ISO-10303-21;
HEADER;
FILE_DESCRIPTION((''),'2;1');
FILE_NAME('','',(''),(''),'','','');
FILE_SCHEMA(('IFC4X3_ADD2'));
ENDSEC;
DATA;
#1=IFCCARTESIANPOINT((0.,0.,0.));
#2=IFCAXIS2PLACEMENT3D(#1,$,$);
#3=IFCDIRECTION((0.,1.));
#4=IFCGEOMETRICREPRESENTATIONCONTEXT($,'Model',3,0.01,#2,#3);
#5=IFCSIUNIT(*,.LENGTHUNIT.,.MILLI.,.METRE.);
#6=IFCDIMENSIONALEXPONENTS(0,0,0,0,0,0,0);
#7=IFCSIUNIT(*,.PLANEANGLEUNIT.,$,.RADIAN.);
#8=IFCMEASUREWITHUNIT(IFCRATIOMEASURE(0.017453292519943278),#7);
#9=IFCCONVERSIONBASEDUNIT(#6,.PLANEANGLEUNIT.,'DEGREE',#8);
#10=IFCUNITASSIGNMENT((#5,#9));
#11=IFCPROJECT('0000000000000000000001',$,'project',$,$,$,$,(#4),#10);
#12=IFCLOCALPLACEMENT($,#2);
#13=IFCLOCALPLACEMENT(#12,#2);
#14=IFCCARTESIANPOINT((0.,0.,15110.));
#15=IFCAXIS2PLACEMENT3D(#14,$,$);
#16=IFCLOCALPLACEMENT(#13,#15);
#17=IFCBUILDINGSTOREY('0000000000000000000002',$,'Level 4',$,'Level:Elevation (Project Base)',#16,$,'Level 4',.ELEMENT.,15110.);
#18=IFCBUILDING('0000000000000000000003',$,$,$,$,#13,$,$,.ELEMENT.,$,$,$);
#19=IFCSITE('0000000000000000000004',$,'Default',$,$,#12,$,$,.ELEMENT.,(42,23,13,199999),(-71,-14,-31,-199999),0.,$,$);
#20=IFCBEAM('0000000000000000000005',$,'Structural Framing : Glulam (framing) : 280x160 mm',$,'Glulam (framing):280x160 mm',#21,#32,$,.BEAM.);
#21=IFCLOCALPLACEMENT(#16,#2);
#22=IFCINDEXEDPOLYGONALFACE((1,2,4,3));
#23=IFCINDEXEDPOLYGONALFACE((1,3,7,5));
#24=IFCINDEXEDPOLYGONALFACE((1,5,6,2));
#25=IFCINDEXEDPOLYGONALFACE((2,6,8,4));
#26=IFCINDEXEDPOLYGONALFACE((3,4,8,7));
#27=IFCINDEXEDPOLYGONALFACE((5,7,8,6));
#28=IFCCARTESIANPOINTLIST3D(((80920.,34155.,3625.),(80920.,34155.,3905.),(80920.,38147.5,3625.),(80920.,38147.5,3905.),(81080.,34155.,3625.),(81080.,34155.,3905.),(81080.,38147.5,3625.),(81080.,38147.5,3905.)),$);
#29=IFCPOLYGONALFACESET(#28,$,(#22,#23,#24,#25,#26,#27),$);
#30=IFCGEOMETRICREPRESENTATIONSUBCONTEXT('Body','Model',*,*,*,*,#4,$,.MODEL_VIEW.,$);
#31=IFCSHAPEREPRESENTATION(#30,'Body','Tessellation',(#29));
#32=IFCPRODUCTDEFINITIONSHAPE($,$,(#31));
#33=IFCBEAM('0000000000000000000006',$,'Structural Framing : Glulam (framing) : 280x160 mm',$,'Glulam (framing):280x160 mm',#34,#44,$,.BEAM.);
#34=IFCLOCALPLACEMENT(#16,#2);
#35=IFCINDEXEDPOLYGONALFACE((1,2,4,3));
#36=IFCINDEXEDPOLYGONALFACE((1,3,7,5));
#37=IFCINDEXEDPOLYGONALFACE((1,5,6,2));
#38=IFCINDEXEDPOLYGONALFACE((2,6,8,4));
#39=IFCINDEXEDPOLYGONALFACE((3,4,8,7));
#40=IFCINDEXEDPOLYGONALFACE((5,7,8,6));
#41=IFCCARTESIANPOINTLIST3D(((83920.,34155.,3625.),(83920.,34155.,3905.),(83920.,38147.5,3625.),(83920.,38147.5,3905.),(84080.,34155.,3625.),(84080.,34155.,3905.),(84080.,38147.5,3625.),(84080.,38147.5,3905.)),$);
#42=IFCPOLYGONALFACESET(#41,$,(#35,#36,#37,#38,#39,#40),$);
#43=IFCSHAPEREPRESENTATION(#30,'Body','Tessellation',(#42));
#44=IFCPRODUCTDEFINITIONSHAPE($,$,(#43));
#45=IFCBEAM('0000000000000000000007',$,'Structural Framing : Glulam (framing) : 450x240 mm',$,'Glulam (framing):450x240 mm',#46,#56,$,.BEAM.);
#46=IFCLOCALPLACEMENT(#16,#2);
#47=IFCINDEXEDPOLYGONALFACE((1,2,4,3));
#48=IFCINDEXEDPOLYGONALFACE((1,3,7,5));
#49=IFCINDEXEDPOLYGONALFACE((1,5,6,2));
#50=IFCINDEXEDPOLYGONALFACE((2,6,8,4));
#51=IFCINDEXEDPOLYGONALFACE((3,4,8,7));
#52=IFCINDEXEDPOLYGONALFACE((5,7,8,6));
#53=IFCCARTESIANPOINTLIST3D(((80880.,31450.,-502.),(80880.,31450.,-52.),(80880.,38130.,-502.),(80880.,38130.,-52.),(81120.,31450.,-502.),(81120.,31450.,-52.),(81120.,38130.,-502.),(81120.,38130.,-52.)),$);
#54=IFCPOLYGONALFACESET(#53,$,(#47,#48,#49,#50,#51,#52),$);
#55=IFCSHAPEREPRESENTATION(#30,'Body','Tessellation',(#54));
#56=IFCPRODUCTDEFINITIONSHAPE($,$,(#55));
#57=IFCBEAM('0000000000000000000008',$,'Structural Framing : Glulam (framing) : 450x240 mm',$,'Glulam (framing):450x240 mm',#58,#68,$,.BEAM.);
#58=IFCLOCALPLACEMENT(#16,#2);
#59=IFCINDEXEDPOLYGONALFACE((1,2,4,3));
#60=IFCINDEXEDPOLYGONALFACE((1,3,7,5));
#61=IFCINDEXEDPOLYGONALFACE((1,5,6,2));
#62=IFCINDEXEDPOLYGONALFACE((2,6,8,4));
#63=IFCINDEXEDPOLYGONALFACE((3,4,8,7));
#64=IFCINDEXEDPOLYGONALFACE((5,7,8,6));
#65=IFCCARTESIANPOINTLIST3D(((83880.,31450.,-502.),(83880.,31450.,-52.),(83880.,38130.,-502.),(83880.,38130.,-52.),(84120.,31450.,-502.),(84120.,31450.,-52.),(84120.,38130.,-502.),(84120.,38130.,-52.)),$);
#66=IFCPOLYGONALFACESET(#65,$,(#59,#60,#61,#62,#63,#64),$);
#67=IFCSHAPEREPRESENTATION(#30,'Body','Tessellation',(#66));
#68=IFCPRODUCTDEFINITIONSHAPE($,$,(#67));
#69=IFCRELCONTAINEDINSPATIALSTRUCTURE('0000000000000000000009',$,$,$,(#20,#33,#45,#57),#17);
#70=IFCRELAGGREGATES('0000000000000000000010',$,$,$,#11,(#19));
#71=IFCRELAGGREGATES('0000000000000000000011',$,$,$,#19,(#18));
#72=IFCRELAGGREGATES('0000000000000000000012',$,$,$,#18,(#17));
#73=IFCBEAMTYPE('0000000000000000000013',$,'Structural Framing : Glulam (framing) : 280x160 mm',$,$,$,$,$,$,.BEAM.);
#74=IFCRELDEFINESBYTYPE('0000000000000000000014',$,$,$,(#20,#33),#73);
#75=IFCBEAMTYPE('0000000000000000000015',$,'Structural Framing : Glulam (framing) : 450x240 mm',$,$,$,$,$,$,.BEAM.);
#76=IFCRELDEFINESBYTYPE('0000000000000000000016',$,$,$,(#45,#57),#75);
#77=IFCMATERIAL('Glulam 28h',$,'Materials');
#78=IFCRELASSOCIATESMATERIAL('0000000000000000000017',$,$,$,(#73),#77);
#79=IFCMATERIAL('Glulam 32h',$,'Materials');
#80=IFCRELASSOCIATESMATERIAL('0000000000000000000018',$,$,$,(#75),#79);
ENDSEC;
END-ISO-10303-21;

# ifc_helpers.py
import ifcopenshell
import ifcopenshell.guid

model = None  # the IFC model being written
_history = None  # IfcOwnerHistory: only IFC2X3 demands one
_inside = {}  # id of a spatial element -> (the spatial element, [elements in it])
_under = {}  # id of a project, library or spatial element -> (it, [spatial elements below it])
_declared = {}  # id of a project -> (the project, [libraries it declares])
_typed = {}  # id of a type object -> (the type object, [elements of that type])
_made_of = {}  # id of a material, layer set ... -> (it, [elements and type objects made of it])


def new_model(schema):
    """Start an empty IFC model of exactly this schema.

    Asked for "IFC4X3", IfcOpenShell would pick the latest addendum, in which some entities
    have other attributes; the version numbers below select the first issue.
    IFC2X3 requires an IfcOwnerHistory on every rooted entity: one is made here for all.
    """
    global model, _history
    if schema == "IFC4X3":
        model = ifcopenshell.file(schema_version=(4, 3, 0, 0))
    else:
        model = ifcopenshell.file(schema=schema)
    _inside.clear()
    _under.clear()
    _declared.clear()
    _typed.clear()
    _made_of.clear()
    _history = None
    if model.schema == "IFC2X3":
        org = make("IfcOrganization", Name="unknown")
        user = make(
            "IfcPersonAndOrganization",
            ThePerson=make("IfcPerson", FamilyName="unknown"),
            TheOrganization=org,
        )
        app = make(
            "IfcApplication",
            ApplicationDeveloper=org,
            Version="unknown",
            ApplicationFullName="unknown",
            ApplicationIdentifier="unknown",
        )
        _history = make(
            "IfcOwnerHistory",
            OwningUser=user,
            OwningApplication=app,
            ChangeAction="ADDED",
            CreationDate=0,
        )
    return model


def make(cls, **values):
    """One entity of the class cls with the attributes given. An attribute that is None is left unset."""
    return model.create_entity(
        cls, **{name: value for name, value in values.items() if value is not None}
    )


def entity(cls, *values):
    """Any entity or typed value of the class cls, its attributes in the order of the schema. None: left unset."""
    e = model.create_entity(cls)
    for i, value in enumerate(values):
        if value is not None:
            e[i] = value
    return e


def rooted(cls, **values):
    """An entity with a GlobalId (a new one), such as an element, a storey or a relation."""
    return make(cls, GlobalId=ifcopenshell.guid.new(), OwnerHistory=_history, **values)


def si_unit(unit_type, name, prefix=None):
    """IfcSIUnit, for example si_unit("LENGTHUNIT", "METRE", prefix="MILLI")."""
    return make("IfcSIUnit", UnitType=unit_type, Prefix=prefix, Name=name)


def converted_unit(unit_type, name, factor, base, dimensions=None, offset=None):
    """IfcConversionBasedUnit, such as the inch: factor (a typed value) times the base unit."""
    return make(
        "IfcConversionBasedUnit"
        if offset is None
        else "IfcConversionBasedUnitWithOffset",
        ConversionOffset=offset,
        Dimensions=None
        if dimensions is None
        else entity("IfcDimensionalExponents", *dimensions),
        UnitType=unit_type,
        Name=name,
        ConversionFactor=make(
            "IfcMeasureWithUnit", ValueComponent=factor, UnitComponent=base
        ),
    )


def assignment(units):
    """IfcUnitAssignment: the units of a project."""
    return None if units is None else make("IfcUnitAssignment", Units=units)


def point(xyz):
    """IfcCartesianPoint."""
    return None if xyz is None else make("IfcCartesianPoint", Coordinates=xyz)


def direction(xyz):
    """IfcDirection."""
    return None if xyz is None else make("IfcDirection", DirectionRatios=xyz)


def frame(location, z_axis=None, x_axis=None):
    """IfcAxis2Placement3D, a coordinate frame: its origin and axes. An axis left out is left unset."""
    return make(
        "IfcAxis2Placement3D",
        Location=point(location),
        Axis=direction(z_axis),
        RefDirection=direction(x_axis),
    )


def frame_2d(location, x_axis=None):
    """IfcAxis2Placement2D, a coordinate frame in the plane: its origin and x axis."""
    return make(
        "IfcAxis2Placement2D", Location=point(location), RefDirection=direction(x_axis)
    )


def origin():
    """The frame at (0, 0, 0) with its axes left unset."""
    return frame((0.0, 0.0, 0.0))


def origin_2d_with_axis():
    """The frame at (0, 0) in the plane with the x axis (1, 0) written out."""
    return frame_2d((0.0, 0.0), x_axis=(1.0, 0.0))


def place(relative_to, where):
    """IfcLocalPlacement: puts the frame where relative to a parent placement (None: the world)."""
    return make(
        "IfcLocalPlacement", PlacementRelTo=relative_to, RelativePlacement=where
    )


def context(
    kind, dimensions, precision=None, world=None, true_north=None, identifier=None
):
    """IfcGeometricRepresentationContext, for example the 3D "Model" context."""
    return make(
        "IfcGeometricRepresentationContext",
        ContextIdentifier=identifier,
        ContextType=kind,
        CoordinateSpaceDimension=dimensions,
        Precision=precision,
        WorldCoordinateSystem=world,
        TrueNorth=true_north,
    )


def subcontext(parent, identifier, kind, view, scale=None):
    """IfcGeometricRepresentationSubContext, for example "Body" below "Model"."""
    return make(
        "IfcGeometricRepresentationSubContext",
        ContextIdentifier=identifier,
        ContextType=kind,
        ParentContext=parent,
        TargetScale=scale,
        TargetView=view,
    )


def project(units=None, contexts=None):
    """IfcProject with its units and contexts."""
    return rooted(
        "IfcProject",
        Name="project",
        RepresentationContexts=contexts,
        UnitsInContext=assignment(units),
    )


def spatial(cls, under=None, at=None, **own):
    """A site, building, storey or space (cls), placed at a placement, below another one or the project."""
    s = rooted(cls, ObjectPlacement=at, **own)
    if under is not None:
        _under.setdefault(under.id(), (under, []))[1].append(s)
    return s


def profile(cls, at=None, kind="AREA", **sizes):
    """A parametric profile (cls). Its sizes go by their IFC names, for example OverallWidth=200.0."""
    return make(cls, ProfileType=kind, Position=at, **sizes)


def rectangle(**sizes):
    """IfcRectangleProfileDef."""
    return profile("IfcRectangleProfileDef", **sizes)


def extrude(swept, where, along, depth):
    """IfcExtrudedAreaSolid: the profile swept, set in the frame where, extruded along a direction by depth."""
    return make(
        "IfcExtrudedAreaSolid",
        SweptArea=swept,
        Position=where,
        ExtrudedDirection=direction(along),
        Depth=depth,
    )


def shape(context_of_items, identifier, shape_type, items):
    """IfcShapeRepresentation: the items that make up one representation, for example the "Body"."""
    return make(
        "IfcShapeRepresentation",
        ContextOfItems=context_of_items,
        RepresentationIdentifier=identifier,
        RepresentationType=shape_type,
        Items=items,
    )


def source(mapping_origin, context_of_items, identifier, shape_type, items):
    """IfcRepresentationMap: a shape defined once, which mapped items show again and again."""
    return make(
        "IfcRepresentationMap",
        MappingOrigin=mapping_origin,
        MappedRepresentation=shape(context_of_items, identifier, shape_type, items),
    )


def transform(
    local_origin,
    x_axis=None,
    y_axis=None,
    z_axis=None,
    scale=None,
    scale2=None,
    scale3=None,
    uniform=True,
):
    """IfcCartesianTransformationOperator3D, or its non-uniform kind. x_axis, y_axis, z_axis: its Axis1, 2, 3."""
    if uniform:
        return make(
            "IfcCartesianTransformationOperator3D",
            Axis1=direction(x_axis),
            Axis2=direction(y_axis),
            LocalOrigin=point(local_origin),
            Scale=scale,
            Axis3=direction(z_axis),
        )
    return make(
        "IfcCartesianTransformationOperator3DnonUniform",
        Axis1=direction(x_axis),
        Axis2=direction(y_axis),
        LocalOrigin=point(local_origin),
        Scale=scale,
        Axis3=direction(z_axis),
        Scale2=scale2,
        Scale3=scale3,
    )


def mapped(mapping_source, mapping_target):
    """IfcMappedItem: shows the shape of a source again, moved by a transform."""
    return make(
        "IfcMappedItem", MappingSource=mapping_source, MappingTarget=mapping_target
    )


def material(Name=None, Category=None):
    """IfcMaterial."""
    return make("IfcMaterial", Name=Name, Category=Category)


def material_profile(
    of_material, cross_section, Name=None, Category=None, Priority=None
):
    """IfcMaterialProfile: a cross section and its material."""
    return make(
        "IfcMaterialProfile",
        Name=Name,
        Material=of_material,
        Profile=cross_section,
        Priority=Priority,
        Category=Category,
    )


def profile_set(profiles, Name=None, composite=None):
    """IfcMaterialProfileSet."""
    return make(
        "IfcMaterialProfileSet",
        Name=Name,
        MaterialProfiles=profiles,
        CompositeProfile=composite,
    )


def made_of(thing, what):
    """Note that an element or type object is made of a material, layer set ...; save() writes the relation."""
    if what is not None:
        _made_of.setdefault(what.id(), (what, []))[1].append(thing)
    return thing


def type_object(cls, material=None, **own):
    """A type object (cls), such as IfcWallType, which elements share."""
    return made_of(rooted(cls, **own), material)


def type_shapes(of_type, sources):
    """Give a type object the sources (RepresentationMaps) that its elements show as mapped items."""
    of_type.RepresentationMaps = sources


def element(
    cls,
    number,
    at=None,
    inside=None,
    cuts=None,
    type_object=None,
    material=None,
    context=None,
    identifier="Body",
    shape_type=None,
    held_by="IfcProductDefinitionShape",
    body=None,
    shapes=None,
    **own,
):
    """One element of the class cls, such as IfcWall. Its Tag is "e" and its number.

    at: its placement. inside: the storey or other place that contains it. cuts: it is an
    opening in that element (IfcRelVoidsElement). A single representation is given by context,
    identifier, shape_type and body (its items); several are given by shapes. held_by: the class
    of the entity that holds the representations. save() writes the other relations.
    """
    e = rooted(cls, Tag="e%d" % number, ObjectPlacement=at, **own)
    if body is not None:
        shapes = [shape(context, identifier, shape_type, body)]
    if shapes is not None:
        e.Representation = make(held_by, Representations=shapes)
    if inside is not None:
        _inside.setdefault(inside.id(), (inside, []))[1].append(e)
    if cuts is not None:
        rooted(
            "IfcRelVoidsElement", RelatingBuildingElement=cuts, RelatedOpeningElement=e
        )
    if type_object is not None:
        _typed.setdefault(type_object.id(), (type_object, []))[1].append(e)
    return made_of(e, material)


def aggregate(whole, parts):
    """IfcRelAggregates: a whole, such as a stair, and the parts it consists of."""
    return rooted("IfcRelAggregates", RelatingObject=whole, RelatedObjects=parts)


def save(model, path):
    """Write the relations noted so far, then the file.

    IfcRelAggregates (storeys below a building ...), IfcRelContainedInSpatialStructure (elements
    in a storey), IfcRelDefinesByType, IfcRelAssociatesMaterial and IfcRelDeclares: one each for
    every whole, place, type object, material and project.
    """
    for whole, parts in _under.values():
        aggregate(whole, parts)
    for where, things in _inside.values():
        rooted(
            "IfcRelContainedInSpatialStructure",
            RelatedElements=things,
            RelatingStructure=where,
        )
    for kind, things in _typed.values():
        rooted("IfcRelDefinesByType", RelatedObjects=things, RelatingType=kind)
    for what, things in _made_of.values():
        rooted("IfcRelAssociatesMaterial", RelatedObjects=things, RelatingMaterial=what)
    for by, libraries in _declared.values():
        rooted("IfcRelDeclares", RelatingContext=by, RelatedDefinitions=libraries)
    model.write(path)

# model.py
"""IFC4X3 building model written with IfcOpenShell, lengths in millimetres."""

from ifc_helpers import new_model, entity, si_unit, converted_unit, direction, frame, origin, origin_2d_with_axis, place, context, subcontext, project, spatial, rectangle, extrude, source, transform, mapped, material, material_profile, profile_set, type_object, type_shapes, element, save


model = new_model("IFC4X3")

# Units and contexts
model_context = context("Model", 3, precision=0.01, world=origin(), true_north=direction((0.0, 1.0)))
body_context = subcontext(model_context, "Body", "Model", "MODEL_VIEW")
ifc_project = project(units=[si_unit("LENGTHUNIT", "METRE", prefix="MILLI"), converted_unit("PLANEANGLEUNIT", "DEGREE", entity("IfcRatioMeasure", 0.017453292519943278), si_unit("PLANEANGLEUNIT", "RADIAN"), dimensions=[0, 0, 0, 0, 0, 0, 0])], contexts=[model_context])

# Site, building, storey
site_placement = place(None, origin())
site = spatial("IfcSite", under=ifc_project, at=site_placement, Name="Default", CompositionType="ELEMENT", RefLatitude=(42, 23, 13, 199999), RefLongitude=(-71, -14, -31, -199999), RefElevation=0.0)
building_placement = place(site_placement, origin())
building = spatial("IfcBuilding", under=site, at=building_placement, CompositionType="ELEMENT")
storey_placement = place(building_placement, frame((0.0, 0.0, 15110.0)))
storey = spatial("IfcBuildingStorey", under=building, at=storey_placement, Name="Level 4", ObjectType="Level:Elevation (Project Base)", LongName="Level 4", CompositionType="ELEMENT", Elevation=15110.0)

# Beams
ifc_material_1 = material(Name="Glulam 28h", Category="Materials")
ifc_material_profile_1 = material_profile(ifc_material_1, rectangle(XDim=280.0, YDim=160.0, at=origin_2d_with_axis()), Name="280x160 mm")
ifc_profile_set_1 = profile_set([ifc_material_profile_1], Name="280x160 mm")
beam_type_1 = type_object("IfcBeamType", Name="Structural Framing : Glulam (framing) : 280x160 mm", PredefinedType="BEAM", material=ifc_profile_set_1)
shared_shape_1 = source(origin(), body_context, "Body", "SweptSolid", [
    extrude(rectangle(XDim=280.0, YDim=160.0, at=origin_2d_with_axis()), frame((-363.8, 0.0, 0.0), z_axis=(1.0, 0.0, 0.0), x_axis=(0.0, 0.0, -1.0)), (0.0, 0.0, 1.0), 3992.5),
])
type_shapes(beam_type_1, [shared_shape_1])
for number, where, z_axis, x_axis, name in (
    (1, (81000.0, 37783.7, 3765.0), (0.0, 0.0, 1.0), (0.0, -1.0, 0.0), "Structural Framing : Glulam (framing) : 280x160 mm"),
    (2, (84000.0, 37783.7, 3765.0), (0.0, 0.0, 1.0), (0.0, -1.0, 0.0), "Structural Framing : Glulam (framing) : 280x160 mm"),
):
    element("IfcBeam", number, at=place(storey_placement, frame(where, z_axis=z_axis, x_axis=x_axis)), inside=storey, type_object=beam_type_1, Name=name, ObjectType="Glulam (framing):280x160 mm", PredefinedType="BEAM", context=body_context, shape_type="MappedRepresentation", body=[
        mapped(shared_shape_1, transform((0.0, 0.0, 0.0), scale=1.0)),
    ])
ifc_material_2 = material(Name="Glulam 32h", Category="Materials")
ifc_material_profile_2 = material_profile(ifc_material_2, rectangle(XDim=450.0, YDim=240.0, at=origin_2d_with_axis()), Name="450x240 mm")
ifc_profile_set_2 = profile_set([ifc_material_profile_2], Name="450x240 mm")
beam_type_2 = type_object("IfcBeamType", Name="Structural Framing : Glulam (framing) : 450x240 mm", PredefinedType="BEAM", material=ifc_profile_set_2)
shared_shape_2 = source(origin(), body_context, "Body", "SweptSolid", [
    extrude(rectangle(XDim=450.0, YDim=240.0, at=origin_2d_with_axis()), frame((-646.3, 0.0, 0.0), z_axis=(1.0, 0.0, 0.0), x_axis=(0.0, 0.0, -1.0)), (0.0, 0.0, 1.0), 6680.0),
])
type_shapes(beam_type_2, [shared_shape_2])
for number, where, z_axis, x_axis, name in (
    (3, (81000.0, 37483.7, -277.0), (0.0, 0.0, 1.0), (0.0, -1.0, 0.0), "Structural Framing : Glulam (framing) : 450x240 mm"),
    (4, (84000.0, 37483.7, -277.0), (0.0, 0.0, 1.0), (0.0, -1.0, 0.0), "Structural Framing : Glulam (framing) : 450x240 mm"),
):
    element("IfcBeam", number, at=place(storey_placement, frame(where, z_axis=z_axis, x_axis=x_axis)), inside=storey, type_object=beam_type_2, Name=name, ObjectType="Glulam (framing):450x240 mm", PredefinedType="BEAM", context=body_context, shape_type="MappedRepresentation", body=[
        mapped(shared_shape_2, transform((0.0, 0.0, 0.0), scale=1.0)),
    ])

save(model, "model.ifc")
